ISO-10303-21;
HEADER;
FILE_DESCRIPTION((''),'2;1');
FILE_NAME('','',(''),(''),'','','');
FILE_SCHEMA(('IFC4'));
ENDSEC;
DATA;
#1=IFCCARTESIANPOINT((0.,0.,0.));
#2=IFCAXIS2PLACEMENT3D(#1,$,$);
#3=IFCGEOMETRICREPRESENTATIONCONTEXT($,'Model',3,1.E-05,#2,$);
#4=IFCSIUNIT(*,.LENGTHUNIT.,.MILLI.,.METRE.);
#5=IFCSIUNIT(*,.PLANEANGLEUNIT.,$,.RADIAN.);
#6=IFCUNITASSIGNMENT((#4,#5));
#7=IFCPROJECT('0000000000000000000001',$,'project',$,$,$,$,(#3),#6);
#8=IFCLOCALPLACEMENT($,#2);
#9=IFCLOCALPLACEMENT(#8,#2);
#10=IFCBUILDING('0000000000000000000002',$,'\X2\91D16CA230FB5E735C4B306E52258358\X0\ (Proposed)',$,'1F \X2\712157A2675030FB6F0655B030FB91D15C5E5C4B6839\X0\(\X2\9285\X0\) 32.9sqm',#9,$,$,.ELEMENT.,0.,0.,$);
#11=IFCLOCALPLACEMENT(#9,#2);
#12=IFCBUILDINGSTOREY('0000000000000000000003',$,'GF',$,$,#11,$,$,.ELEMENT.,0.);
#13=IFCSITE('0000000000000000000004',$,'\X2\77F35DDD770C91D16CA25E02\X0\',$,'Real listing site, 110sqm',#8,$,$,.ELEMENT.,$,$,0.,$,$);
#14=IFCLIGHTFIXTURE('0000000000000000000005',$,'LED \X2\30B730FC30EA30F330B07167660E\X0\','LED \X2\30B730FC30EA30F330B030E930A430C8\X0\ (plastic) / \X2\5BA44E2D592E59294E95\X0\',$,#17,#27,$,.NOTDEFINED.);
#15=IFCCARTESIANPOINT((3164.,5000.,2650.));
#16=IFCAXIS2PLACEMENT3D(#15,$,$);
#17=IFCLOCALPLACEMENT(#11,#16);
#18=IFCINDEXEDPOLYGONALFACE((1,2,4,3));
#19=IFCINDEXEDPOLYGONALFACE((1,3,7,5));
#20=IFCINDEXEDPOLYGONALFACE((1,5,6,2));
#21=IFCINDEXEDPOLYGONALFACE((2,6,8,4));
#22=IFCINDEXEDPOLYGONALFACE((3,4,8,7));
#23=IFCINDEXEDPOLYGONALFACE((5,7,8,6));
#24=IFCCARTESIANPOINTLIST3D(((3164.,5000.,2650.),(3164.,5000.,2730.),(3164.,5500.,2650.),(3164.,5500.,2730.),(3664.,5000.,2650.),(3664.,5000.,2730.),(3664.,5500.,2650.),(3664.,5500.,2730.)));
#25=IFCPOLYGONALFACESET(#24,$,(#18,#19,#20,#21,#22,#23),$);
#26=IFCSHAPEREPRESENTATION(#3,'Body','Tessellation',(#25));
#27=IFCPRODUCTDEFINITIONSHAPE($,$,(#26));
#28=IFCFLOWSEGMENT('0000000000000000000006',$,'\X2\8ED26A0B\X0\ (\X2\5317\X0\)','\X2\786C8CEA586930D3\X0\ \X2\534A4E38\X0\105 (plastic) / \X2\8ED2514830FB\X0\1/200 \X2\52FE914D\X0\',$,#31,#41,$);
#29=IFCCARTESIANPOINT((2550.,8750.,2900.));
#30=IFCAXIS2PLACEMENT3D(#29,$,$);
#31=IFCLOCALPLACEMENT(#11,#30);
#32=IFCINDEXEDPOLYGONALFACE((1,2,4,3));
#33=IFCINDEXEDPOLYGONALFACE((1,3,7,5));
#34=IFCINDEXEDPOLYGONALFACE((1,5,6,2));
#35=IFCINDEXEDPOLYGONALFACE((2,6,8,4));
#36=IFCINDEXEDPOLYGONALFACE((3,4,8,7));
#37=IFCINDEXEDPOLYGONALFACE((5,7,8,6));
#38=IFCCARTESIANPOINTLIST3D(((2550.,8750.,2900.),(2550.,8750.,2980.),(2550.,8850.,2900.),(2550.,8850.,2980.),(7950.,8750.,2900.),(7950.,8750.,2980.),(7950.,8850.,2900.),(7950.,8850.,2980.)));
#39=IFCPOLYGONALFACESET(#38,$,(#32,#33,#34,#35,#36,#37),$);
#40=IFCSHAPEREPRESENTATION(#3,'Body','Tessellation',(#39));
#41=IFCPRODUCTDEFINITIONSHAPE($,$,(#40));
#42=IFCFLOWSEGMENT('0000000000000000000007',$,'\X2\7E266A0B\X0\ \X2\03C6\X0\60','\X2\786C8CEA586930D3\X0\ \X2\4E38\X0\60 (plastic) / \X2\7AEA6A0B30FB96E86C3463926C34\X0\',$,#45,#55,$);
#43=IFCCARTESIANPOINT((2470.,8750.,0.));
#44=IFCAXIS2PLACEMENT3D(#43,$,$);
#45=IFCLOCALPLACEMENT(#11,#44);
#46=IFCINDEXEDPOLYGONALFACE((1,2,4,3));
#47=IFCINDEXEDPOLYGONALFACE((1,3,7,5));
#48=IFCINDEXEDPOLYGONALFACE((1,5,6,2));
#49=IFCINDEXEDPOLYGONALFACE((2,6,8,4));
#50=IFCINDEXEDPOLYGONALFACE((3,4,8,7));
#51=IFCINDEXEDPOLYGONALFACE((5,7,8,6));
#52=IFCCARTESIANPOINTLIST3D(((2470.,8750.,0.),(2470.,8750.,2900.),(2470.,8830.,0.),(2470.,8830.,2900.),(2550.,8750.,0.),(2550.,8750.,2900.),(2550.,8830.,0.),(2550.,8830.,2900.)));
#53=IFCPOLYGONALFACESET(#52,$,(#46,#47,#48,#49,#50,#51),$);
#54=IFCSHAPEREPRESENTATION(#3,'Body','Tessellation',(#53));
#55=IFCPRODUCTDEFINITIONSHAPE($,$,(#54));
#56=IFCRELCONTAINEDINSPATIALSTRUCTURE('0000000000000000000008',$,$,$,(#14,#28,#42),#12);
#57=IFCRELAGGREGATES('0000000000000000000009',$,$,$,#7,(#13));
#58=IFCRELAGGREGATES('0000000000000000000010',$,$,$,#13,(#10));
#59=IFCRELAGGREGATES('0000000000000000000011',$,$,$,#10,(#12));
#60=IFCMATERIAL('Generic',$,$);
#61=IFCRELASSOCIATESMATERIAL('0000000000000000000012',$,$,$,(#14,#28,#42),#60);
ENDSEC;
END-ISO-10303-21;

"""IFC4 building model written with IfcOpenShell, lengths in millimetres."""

from ifc_helpers import new_model, si_unit, frame, frame_2d, origin, place, context, project, spatial, rectangle, extrude, material, element, save


model = new_model("IFC4")

# Units and contexts
model_context = context("Model", 3, precision=1e-05, world=origin())
ifc_project = project(units=[si_unit("LENGTHUNIT", "METRE", prefix="MILLI"), si_unit("PLANEANGLEUNIT", "RADIAN")], contexts=[model_context])

# Site, building, storey
site_placement = place(None, origin())
site = spatial("IfcSite", under=ifc_project, at=site_placement, Name="石川県金沢市", ObjectType="Real listing site, 110sqm", CompositionType="ELEMENT", RefElevation=0.0)
building_placement = place(site_placement, origin())
building = spatial("IfcBuilding", under=site, at=building_placement, Name="金沢・平屋の別荘 (Proposed)", ObjectType="1F 無垢材・漆喰・金属屋根(銅) 32.9sqm", CompositionType="ELEMENT", ElevationOfRefHeight=0.0, ElevationOfTerrain=0.0)
storey_placement = place(building_placement, origin())
storey = spatial("IfcBuildingStorey", under=building, at=storey_placement, Name="GF", CompositionType="ELEMENT", Elevation=0.0)

# Shared definitions
ifc_material_1 = material(Name="Generic")

# Light fixture
light_fixture_placement = place(storey_placement, frame((3164.0, 5000.0, 2650.0)))
element("IfcLightFixture", 1, at=light_fixture_placement, inside=storey, material=ifc_material_1, Name="LED シーリング照明", Description="LED シーリングライト (plastic) / 室中央天井", PredefinedType="NOTDEFINED", context=model_context, shape_type="SweptSolid", body=[
    extrude(rectangle(XDim=500.0, YDim=500.0, at=frame_2d((250.0, 250.0))), frame((3164.0, 5000.0, 2650.0)), (0.0, 0.0, 1.0), 80.0),
])

# Flow segments
flow_segment_1_placement = place(storey_placement, frame((2550.0, 8750.0, 2900.0)))
element("IfcFlowSegment", 2, at=flow_segment_1_placement, inside=storey, material=ifc_material_1, Name="軒樋 (北)", Description="硬質塩ビ 半丸105 (plastic) / 軒先・1/200 勾配", context=model_context, shape_type="SweptSolid", body=[
    extrude(rectangle(XDim=5400.0, YDim=100.0, at=frame_2d((2700.0, 50.0))), frame((2550.0, 8750.0, 2900.0)), (0.0, 0.0, 1.0), 80.0),
])
flow_segment_2_placement = place(storey_placement, frame((2470.0, 8750.0, 0.0)))
element("IfcFlowSegment", 3, at=flow_segment_2_placement, inside=storey, material=ifc_material_1, Name="縦樋 φ60", Description="硬質塩ビ 丸60 (plastic) / 竪樋・雨水排水", context=model_context, shape_type="SweptSolid", body=[
    extrude(rectangle(XDim=80.0, YDim=80.0, at=frame_2d((40.0, 40.0))), frame((2470.0, 8750.0, 0.0)), (0.0, 0.0, 1.0), 2900.0),
])

save(model, "model.ifc")
